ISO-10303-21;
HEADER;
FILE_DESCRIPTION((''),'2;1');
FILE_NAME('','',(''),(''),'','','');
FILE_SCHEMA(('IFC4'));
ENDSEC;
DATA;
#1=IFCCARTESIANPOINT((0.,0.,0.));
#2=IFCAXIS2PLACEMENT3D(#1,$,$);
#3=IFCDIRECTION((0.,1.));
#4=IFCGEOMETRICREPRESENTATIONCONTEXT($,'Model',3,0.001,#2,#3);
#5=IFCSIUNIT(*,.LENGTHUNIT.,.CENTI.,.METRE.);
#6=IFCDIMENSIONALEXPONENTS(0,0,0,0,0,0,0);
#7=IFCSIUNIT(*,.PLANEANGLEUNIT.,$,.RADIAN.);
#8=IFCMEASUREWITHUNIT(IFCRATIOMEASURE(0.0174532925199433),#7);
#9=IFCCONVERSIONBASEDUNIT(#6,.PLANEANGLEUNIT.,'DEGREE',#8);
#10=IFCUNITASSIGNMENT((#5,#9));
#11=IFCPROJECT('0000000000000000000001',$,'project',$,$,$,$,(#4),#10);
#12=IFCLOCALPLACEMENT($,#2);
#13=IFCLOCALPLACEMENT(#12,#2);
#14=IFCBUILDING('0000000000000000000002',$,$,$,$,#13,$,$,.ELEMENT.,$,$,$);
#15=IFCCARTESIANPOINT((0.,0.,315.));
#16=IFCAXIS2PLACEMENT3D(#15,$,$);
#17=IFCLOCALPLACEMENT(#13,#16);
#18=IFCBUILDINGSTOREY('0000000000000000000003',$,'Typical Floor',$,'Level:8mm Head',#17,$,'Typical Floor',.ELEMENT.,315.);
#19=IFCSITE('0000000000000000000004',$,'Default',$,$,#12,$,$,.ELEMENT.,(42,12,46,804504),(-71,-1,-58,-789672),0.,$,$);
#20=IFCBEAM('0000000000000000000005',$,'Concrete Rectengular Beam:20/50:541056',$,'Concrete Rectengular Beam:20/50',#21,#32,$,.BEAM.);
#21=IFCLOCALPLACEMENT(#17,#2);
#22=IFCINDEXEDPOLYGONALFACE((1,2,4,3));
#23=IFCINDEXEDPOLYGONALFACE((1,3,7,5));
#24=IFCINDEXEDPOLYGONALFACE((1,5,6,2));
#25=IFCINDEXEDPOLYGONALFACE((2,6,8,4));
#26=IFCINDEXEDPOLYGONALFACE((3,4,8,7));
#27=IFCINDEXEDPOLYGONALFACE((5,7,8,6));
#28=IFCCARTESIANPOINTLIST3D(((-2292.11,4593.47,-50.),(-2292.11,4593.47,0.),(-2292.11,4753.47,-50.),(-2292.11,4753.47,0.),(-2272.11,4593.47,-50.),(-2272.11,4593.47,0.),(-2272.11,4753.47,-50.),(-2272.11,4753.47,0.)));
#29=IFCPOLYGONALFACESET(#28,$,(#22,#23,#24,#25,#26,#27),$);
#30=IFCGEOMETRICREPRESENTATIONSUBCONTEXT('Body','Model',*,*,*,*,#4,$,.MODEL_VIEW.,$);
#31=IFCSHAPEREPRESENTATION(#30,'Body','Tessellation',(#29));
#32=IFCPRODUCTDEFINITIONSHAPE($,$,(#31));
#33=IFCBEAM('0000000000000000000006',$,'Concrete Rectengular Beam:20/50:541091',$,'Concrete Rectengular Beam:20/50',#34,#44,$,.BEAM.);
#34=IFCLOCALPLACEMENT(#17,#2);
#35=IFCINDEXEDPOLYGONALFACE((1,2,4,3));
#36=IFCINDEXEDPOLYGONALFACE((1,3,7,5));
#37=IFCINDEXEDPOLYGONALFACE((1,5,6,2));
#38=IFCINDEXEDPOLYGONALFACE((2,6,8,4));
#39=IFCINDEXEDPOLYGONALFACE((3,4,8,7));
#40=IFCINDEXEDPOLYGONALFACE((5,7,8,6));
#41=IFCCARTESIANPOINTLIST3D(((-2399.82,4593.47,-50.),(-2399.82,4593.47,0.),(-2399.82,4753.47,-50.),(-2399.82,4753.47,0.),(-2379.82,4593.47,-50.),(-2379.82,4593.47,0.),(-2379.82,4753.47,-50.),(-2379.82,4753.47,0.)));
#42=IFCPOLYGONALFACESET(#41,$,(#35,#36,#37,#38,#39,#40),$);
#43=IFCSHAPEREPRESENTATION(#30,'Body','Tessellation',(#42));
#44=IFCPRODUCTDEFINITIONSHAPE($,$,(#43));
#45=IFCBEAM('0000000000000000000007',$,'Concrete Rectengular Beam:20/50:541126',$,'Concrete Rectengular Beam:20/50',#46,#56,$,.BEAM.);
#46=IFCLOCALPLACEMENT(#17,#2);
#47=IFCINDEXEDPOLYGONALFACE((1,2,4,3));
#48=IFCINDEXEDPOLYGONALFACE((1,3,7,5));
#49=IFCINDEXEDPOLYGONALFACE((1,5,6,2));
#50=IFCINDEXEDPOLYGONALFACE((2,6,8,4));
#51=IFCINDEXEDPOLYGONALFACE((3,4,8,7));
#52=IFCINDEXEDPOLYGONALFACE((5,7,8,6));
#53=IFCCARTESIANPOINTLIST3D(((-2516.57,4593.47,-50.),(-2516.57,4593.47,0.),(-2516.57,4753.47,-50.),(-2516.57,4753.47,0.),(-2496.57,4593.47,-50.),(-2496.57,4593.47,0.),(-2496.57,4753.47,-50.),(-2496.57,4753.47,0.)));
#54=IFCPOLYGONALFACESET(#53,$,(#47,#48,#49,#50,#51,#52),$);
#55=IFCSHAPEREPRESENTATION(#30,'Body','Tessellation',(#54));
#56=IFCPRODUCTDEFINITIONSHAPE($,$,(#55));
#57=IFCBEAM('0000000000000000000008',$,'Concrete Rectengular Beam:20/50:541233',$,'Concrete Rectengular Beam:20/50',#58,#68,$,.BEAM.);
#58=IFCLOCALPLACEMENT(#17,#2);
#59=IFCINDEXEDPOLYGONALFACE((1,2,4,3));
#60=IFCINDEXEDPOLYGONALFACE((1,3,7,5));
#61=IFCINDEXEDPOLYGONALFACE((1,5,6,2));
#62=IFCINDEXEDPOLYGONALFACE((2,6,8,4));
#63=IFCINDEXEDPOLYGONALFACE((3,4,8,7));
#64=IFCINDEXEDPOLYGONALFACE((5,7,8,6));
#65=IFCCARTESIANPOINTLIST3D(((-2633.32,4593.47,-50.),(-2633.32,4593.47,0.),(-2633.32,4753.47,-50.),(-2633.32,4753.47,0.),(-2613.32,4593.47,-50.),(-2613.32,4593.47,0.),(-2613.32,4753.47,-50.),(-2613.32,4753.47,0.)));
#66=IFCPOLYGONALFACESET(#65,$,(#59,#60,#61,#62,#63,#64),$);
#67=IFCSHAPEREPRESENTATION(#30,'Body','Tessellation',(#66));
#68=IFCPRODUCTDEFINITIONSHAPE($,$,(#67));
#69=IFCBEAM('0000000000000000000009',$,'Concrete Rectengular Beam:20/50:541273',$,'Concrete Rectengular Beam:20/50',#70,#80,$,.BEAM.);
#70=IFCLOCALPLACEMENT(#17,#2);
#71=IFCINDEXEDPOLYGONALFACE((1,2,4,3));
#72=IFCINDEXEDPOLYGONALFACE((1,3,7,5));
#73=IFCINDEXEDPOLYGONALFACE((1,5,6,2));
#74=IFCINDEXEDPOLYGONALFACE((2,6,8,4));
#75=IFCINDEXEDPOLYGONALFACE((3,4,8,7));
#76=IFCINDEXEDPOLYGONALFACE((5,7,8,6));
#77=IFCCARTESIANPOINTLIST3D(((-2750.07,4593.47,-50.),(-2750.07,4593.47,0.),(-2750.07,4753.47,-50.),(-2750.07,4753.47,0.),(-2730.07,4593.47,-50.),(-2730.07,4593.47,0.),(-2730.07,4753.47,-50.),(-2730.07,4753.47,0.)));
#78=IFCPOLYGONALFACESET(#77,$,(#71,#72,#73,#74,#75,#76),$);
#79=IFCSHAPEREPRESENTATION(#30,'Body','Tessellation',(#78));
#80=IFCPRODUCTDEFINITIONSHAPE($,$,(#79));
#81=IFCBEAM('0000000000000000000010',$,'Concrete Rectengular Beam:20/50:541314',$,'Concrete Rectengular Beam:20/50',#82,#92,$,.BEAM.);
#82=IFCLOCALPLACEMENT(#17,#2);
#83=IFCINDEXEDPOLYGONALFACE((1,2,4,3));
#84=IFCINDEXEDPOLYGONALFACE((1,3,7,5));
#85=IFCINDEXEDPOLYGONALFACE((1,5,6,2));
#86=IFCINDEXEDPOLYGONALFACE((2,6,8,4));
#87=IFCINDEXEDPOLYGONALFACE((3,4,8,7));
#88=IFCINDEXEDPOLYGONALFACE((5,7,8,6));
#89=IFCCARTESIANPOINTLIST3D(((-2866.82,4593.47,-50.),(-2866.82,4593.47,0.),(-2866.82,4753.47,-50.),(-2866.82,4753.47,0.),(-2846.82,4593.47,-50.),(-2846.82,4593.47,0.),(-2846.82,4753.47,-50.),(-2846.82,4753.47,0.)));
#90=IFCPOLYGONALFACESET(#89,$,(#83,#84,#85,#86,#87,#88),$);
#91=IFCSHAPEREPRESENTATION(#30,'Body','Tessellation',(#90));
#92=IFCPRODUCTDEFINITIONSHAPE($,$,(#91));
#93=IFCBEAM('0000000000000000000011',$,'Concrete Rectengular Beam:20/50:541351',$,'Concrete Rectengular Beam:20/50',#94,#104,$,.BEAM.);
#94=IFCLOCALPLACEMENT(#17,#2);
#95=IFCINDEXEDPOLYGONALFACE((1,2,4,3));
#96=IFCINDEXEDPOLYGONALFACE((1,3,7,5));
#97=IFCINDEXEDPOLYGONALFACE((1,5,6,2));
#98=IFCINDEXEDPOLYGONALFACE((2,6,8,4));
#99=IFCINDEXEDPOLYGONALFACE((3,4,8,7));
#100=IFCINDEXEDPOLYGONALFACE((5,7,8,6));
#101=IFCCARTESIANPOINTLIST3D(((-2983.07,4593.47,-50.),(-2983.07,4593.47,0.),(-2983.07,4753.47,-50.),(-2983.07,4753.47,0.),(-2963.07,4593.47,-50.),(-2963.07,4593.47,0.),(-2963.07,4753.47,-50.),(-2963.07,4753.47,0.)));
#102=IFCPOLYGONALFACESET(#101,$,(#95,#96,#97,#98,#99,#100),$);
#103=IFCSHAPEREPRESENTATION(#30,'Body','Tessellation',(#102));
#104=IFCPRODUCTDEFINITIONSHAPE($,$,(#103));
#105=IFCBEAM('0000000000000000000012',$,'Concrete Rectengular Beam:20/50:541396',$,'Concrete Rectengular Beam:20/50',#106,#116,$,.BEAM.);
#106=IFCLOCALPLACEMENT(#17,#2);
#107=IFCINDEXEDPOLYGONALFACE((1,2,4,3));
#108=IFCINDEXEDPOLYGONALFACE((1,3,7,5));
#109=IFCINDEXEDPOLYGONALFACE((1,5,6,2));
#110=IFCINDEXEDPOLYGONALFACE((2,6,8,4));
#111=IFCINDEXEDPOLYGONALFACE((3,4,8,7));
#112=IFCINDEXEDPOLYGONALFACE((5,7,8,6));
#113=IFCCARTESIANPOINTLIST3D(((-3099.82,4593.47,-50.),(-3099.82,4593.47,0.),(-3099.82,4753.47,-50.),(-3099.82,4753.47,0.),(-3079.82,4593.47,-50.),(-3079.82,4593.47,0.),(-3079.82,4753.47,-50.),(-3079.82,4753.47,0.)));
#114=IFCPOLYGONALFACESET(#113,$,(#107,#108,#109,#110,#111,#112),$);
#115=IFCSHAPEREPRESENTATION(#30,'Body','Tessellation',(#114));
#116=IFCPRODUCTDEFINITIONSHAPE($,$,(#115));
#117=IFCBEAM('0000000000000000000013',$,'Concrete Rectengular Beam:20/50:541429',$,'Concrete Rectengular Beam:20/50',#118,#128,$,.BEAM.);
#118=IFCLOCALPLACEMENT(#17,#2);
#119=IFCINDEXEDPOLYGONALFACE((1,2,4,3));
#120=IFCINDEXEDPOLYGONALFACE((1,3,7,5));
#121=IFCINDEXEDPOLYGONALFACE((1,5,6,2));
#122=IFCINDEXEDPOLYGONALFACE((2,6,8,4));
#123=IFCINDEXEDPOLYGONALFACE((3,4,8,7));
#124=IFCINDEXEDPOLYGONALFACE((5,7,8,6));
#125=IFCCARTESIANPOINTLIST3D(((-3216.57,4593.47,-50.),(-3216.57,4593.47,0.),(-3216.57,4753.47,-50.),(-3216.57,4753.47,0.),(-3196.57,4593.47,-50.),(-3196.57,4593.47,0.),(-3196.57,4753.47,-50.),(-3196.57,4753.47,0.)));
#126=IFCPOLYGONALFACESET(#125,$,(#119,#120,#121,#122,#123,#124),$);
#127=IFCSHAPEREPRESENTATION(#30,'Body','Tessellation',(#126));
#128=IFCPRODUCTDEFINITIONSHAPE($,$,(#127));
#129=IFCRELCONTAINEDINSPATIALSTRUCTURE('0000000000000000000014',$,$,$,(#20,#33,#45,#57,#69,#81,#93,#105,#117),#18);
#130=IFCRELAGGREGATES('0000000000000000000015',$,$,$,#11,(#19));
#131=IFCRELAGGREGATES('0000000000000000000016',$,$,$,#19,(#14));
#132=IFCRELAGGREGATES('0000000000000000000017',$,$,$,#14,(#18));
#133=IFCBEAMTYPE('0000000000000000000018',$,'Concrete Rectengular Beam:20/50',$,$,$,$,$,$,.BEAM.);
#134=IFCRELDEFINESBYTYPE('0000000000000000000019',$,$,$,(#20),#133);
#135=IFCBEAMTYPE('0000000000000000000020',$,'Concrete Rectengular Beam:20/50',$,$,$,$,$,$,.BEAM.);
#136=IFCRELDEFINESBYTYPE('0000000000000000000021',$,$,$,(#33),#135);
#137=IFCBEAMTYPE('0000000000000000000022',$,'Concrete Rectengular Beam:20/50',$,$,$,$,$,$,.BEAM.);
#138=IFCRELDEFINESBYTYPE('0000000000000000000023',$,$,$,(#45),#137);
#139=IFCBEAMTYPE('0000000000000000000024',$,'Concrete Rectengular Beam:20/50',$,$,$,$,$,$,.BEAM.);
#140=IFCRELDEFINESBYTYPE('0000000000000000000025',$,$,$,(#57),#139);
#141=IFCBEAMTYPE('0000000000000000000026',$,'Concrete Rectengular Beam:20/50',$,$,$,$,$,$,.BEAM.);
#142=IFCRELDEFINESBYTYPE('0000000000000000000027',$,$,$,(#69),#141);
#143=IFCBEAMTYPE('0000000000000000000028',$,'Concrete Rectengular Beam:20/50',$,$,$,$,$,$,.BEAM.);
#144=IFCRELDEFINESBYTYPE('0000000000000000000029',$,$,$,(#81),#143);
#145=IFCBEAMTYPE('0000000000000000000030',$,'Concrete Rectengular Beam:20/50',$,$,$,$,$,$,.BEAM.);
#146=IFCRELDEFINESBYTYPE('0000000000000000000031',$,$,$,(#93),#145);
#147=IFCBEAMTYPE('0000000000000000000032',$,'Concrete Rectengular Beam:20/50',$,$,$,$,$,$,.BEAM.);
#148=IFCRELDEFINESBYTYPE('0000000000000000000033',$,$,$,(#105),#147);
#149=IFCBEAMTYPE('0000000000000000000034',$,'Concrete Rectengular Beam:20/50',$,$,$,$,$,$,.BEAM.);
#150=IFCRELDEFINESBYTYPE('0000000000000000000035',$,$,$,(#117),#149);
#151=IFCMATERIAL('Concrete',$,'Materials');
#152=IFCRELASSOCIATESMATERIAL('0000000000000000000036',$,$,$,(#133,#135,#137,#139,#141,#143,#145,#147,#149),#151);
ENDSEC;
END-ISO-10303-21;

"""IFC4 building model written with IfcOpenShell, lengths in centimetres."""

from ifc_helpers import new_model, entity, si_unit, converted_unit, direction, frame, origin, place, context, subcontext, project, spatial, indexed_curve, outline, extrude, source, transform, mapped, material, type_object, type_shapes, element, save


model = new_model("IFC4")

# Units and contexts
model_context = context("Model", 3, precision=0.001, world=origin(), true_north=direction((0.0, 1.0)))
body_context = subcontext(model_context, "Body", "Model", "MODEL_VIEW")
ifc_project = project(units=[si_unit("LENGTHUNIT", "METRE", prefix="CENTI"), converted_unit("PLANEANGLEUNIT", "DEGREE", entity("IfcRatioMeasure", 0.0174532925199433), si_unit("PLANEANGLEUNIT", "RADIAN"), dimensions=[0, 0, 0, 0, 0, 0, 0])], contexts=[model_context])

# Site, building, storey
site_placement = place(None, origin())
site = spatial("IfcSite", under=ifc_project, at=site_placement, Name="Default", CompositionType="ELEMENT", RefLatitude=(42, 12, 46, 804504), RefLongitude=(-71, -1, -58, -789672), RefElevation=0.0)
building_placement = place(site_placement, origin())
building = spatial("IfcBuilding", under=site, at=building_placement, CompositionType="ELEMENT")
storey_placement = place(building_placement, frame((0.0, 0.0, 315.0)))
storey = spatial("IfcBuildingStorey", under=building, at=storey_placement, Name="Typical Floor", ObjectType="Level:8mm Head", LongName="Typical Floor", CompositionType="ELEMENT", Elevation=315.0)

# Beams
ifc_material = material(Name="Concrete", Category="Materials")
beam_type_1 = type_object("IfcBeamType", Name="Concrete Rectengular Beam:20/50", PredefinedType="BEAM", material=ifc_material)
shared_shape_1 = source(origin(), body_context, "Body", "SweptSolid", [
    extrude(outline(indexed_curve([(-10.0, -25.0), (10.0, -25.0), (10.0, 25.0), (-10.0, 25.0), (-10.0, -25.0)], self_intersect=False)), frame((-2282.11, 4753.47, 290.0), z_axis=(0.0, -1.0, 0.0), x_axis=(-1.0, 0.0, 0.0)), (0.0, 0.0, 1.0), 160.0),
])
type_shapes(beam_type_1, [shared_shape_1])
beam_1_placement = place(storey_placement, frame((0.0, 0.0, -315.0)))
element("IfcBeam", 1, at=beam_1_placement, inside=storey, type_object=beam_type_1, Name="Concrete Rectengular Beam:20/50:541056", ObjectType="Concrete Rectengular Beam:20/50", PredefinedType="BEAM", context=body_context, shape_type="MappedRepresentation", body=[
    mapped(shared_shape_1, transform((0.0, 0.0, 0.0), scale=1.0)),
])
beam_type_2 = type_object("IfcBeamType", Name="Concrete Rectengular Beam:20/50", PredefinedType="BEAM", material=ifc_material)
shared_shape_2 = source(origin(), body_context, "Body", "SweptSolid", [
    extrude(outline(indexed_curve([(-10.0, -25.0), (10.0, -25.0), (10.0, 25.0), (-10.0, 25.0), (-10.0, -25.0)], self_intersect=False)), frame((-2389.82, 4753.47, 290.0), z_axis=(0.0, -1.0, 0.0), x_axis=(-1.0, 0.0, 0.0)), (0.0, 0.0, 1.0), 160.0),
])
type_shapes(beam_type_2, [shared_shape_2])
beam_2_placement = place(storey_placement, frame((0.0, 0.0, -315.0)))
element("IfcBeam", 2, at=beam_2_placement, inside=storey, type_object=beam_type_2, Name="Concrete Rectengular Beam:20/50:541091", ObjectType="Concrete Rectengular Beam:20/50", PredefinedType="BEAM", context=body_context, shape_type="MappedRepresentation", body=[
    mapped(shared_shape_2, transform((0.0, 0.0, 0.0), scale=1.0)),
])
beam_type_3 = type_object("IfcBeamType", Name="Concrete Rectengular Beam:20/50", PredefinedType="BEAM", material=ifc_material)
shared_shape_3 = source(origin(), body_context, "Body", "SweptSolid", [
    extrude(outline(indexed_curve([(-10.0, -25.0), (10.0, -25.0), (10.0, 25.0), (-10.0, 25.0), (-10.0, -25.0)], self_intersect=False)), frame((-2506.57, 4753.47, 290.0), z_axis=(0.0, -1.0, 0.0), x_axis=(-1.0, 0.0, 0.0)), (0.0, 0.0, 1.0), 160.0),
])
type_shapes(beam_type_3, [shared_shape_3])
beam_3_placement = place(storey_placement, frame((0.0, 0.0, -315.0)))
element("IfcBeam", 3, at=beam_3_placement, inside=storey, type_object=beam_type_3, Name="Concrete Rectengular Beam:20/50:541126", ObjectType="Concrete Rectengular Beam:20/50", PredefinedType="BEAM", context=body_context, shape_type="MappedRepresentation", body=[
    mapped(shared_shape_3, transform((0.0, 0.0, 0.0), scale=1.0)),
])
beam_type_4 = type_object("IfcBeamType", Name="Concrete Rectengular Beam:20/50", PredefinedType="BEAM", material=ifc_material)
shared_shape_4 = source(origin(), body_context, "Body", "SweptSolid", [
    extrude(outline(indexed_curve([(-10.0, -25.0), (10.0, -25.0), (10.0, 25.0), (-10.0, 25.0), (-10.0, -25.0)], self_intersect=False)), frame((-2623.32, 4753.47, 290.0), z_axis=(0.0, -1.0, 0.0), x_axis=(-1.0, 0.0, 0.0)), (0.0, 0.0, 1.0), 160.0),
])
type_shapes(beam_type_4, [shared_shape_4])
beam_4_placement = place(storey_placement, frame((0.0, 0.0, -315.0)))
element("IfcBeam", 4, at=beam_4_placement, inside=storey, type_object=beam_type_4, Name="Concrete Rectengular Beam:20/50:541233", ObjectType="Concrete Rectengular Beam:20/50", PredefinedType="BEAM", context=body_context, shape_type="MappedRepresentation", body=[
    mapped(shared_shape_4, transform((0.0, 0.0, 0.0), scale=1.0)),
])
beam_type_5 = type_object("IfcBeamType", Name="Concrete Rectengular Beam:20/50", PredefinedType="BEAM", material=ifc_material)
shared_shape_5 = source(origin(), body_context, "Body", "SweptSolid", [
    extrude(outline(indexed_curve([(-10.0, -25.0), (10.0, -25.0), (10.0, 25.0), (-10.0, 25.0), (-10.0, -25.0)], self_intersect=False)), frame((-2740.07, 4753.47, 290.0), z_axis=(0.0, -1.0, 0.0), x_axis=(-1.0, 0.0, 0.0)), (0.0, 0.0, 1.0), 160.0),
])
type_shapes(beam_type_5, [shared_shape_5])
beam_5_placement = place(storey_placement, frame((0.0, 0.0, -315.0)))
element("IfcBeam", 5, at=beam_5_placement, inside=storey, type_object=beam_type_5, Name="Concrete Rectengular Beam:20/50:541273", ObjectType="Concrete Rectengular Beam:20/50", PredefinedType="BEAM", context=body_context, shape_type="MappedRepresentation", body=[
    mapped(shared_shape_5, transform((0.0, 0.0, 0.0), scale=1.0)),
])
beam_type_6 = type_object("IfcBeamType", Name="Concrete Rectengular Beam:20/50", PredefinedType="BEAM", material=ifc_material)
shared_shape_6 = source(origin(), body_context, "Body", "SweptSolid", [
    extrude(outline(indexed_curve([(-10.0, -25.0), (10.0, -25.0), (10.0, 25.0), (-10.0, 25.0), (-10.0, -25.0)], self_intersect=False)), frame((-2856.82, 4753.47, 290.0), z_axis=(0.0, -1.0, 0.0), x_axis=(-1.0, 0.0, 0.0)), (0.0, 0.0, 1.0), 160.0),
])
type_shapes(beam_type_6, [shared_shape_6])
beam_6_placement = place(storey_placement, frame((0.0, 0.0, -315.0)))
element("IfcBeam", 6, at=beam_6_placement, inside=storey, type_object=beam_type_6, Name="Concrete Rectengular Beam:20/50:541314", ObjectType="Concrete Rectengular Beam:20/50", PredefinedType="BEAM", context=body_context, shape_type="MappedRepresentation", body=[
    mapped(shared_shape_6, transform((0.0, 0.0, 0.0), scale=1.0)),
])
beam_type_7 = type_object("IfcBeamType", Name="Concrete Rectengular Beam:20/50", PredefinedType="BEAM", material=ifc_material)
shared_shape_7 = source(origin(), body_context, "Body", "SweptSolid", [
    extrude(outline(indexed_curve([(-10.0, -25.0), (10.0, -25.0), (10.0, 25.0), (-10.0, 25.0), (-10.0, -25.0)], self_intersect=False)), frame((-2973.07, 4753.47, 290.0), z_axis=(0.0, -1.0, 0.0), x_axis=(-1.0, 0.0, 0.0)), (0.0, 0.0, 1.0), 160.0),
])
type_shapes(beam_type_7, [shared_shape_7])
beam_7_placement = place(storey_placement, frame((0.0, 0.0, -315.0)))
element("IfcBeam", 7, at=beam_7_placement, inside=storey, type_object=beam_type_7, Name="Concrete Rectengular Beam:20/50:541351", ObjectType="Concrete Rectengular Beam:20/50", PredefinedType="BEAM", context=body_context, shape_type="MappedRepresentation", body=[
    mapped(shared_shape_7, transform((0.0, 0.0, 0.0), scale=1.0)),
])
beam_type_8 = type_object("IfcBeamType", Name="Concrete Rectengular Beam:20/50", PredefinedType="BEAM", material=ifc_material)
shared_shape_8 = source(origin(), body_context, "Body", "SweptSolid", [
    extrude(outline(indexed_curve([(-10.0, -25.0), (10.0, -25.0), (10.0, 25.0), (-10.0, 25.0), (-10.0, -25.0)], self_intersect=False)), frame((-3089.82, 4753.47, 290.0), z_axis=(0.0, -1.0, 0.0), x_axis=(-1.0, 0.0, 0.0)), (0.0, 0.0, 1.0), 160.0),
])
type_shapes(beam_type_8, [shared_shape_8])
beam_8_placement = place(storey_placement, frame((0.0, 0.0, -315.0)))
element("IfcBeam", 8, at=beam_8_placement, inside=storey, type_object=beam_type_8, Name="Concrete Rectengular Beam:20/50:541396", ObjectType="Concrete Rectengular Beam:20/50", PredefinedType="BEAM", context=body_context, shape_type="MappedRepresentation", body=[
    mapped(shared_shape_8, transform((0.0, 0.0, 0.0), scale=1.0)),
])
beam_type_9 = type_object("IfcBeamType", Name="Concrete Rectengular Beam:20/50", PredefinedType="BEAM", material=ifc_material)
shared_shape_9 = source(origin(), body_context, "Body", "SweptSolid", [
    extrude(outline(indexed_curve([(-10.0, -25.0), (10.0, -25.0), (10.0, 25.0), (-10.0, 25.0), (-10.0, -25.0)], self_intersect=False)), frame((-3206.57, 4753.47, 290.0), z_axis=(0.0, -1.0, 0.0), x_axis=(-1.0, 0.0, 0.0)), (0.0, 0.0, 1.0), 160.0),
])
type_shapes(beam_type_9, [shared_shape_9])
beam_9_placement = place(storey_placement, frame((0.0, 0.0, -315.0)))
element("IfcBeam", 9, at=beam_9_placement, inside=storey, type_object=beam_type_9, Name="Concrete Rectengular Beam:20/50:541429", ObjectType="Concrete Rectengular Beam:20/50", PredefinedType="BEAM", context=body_context, shape_type="MappedRepresentation", body=[
    mapped(shared_shape_9, transform((0.0, 0.0, 0.0), scale=1.0)),
])

save(model, "model.ifc")
